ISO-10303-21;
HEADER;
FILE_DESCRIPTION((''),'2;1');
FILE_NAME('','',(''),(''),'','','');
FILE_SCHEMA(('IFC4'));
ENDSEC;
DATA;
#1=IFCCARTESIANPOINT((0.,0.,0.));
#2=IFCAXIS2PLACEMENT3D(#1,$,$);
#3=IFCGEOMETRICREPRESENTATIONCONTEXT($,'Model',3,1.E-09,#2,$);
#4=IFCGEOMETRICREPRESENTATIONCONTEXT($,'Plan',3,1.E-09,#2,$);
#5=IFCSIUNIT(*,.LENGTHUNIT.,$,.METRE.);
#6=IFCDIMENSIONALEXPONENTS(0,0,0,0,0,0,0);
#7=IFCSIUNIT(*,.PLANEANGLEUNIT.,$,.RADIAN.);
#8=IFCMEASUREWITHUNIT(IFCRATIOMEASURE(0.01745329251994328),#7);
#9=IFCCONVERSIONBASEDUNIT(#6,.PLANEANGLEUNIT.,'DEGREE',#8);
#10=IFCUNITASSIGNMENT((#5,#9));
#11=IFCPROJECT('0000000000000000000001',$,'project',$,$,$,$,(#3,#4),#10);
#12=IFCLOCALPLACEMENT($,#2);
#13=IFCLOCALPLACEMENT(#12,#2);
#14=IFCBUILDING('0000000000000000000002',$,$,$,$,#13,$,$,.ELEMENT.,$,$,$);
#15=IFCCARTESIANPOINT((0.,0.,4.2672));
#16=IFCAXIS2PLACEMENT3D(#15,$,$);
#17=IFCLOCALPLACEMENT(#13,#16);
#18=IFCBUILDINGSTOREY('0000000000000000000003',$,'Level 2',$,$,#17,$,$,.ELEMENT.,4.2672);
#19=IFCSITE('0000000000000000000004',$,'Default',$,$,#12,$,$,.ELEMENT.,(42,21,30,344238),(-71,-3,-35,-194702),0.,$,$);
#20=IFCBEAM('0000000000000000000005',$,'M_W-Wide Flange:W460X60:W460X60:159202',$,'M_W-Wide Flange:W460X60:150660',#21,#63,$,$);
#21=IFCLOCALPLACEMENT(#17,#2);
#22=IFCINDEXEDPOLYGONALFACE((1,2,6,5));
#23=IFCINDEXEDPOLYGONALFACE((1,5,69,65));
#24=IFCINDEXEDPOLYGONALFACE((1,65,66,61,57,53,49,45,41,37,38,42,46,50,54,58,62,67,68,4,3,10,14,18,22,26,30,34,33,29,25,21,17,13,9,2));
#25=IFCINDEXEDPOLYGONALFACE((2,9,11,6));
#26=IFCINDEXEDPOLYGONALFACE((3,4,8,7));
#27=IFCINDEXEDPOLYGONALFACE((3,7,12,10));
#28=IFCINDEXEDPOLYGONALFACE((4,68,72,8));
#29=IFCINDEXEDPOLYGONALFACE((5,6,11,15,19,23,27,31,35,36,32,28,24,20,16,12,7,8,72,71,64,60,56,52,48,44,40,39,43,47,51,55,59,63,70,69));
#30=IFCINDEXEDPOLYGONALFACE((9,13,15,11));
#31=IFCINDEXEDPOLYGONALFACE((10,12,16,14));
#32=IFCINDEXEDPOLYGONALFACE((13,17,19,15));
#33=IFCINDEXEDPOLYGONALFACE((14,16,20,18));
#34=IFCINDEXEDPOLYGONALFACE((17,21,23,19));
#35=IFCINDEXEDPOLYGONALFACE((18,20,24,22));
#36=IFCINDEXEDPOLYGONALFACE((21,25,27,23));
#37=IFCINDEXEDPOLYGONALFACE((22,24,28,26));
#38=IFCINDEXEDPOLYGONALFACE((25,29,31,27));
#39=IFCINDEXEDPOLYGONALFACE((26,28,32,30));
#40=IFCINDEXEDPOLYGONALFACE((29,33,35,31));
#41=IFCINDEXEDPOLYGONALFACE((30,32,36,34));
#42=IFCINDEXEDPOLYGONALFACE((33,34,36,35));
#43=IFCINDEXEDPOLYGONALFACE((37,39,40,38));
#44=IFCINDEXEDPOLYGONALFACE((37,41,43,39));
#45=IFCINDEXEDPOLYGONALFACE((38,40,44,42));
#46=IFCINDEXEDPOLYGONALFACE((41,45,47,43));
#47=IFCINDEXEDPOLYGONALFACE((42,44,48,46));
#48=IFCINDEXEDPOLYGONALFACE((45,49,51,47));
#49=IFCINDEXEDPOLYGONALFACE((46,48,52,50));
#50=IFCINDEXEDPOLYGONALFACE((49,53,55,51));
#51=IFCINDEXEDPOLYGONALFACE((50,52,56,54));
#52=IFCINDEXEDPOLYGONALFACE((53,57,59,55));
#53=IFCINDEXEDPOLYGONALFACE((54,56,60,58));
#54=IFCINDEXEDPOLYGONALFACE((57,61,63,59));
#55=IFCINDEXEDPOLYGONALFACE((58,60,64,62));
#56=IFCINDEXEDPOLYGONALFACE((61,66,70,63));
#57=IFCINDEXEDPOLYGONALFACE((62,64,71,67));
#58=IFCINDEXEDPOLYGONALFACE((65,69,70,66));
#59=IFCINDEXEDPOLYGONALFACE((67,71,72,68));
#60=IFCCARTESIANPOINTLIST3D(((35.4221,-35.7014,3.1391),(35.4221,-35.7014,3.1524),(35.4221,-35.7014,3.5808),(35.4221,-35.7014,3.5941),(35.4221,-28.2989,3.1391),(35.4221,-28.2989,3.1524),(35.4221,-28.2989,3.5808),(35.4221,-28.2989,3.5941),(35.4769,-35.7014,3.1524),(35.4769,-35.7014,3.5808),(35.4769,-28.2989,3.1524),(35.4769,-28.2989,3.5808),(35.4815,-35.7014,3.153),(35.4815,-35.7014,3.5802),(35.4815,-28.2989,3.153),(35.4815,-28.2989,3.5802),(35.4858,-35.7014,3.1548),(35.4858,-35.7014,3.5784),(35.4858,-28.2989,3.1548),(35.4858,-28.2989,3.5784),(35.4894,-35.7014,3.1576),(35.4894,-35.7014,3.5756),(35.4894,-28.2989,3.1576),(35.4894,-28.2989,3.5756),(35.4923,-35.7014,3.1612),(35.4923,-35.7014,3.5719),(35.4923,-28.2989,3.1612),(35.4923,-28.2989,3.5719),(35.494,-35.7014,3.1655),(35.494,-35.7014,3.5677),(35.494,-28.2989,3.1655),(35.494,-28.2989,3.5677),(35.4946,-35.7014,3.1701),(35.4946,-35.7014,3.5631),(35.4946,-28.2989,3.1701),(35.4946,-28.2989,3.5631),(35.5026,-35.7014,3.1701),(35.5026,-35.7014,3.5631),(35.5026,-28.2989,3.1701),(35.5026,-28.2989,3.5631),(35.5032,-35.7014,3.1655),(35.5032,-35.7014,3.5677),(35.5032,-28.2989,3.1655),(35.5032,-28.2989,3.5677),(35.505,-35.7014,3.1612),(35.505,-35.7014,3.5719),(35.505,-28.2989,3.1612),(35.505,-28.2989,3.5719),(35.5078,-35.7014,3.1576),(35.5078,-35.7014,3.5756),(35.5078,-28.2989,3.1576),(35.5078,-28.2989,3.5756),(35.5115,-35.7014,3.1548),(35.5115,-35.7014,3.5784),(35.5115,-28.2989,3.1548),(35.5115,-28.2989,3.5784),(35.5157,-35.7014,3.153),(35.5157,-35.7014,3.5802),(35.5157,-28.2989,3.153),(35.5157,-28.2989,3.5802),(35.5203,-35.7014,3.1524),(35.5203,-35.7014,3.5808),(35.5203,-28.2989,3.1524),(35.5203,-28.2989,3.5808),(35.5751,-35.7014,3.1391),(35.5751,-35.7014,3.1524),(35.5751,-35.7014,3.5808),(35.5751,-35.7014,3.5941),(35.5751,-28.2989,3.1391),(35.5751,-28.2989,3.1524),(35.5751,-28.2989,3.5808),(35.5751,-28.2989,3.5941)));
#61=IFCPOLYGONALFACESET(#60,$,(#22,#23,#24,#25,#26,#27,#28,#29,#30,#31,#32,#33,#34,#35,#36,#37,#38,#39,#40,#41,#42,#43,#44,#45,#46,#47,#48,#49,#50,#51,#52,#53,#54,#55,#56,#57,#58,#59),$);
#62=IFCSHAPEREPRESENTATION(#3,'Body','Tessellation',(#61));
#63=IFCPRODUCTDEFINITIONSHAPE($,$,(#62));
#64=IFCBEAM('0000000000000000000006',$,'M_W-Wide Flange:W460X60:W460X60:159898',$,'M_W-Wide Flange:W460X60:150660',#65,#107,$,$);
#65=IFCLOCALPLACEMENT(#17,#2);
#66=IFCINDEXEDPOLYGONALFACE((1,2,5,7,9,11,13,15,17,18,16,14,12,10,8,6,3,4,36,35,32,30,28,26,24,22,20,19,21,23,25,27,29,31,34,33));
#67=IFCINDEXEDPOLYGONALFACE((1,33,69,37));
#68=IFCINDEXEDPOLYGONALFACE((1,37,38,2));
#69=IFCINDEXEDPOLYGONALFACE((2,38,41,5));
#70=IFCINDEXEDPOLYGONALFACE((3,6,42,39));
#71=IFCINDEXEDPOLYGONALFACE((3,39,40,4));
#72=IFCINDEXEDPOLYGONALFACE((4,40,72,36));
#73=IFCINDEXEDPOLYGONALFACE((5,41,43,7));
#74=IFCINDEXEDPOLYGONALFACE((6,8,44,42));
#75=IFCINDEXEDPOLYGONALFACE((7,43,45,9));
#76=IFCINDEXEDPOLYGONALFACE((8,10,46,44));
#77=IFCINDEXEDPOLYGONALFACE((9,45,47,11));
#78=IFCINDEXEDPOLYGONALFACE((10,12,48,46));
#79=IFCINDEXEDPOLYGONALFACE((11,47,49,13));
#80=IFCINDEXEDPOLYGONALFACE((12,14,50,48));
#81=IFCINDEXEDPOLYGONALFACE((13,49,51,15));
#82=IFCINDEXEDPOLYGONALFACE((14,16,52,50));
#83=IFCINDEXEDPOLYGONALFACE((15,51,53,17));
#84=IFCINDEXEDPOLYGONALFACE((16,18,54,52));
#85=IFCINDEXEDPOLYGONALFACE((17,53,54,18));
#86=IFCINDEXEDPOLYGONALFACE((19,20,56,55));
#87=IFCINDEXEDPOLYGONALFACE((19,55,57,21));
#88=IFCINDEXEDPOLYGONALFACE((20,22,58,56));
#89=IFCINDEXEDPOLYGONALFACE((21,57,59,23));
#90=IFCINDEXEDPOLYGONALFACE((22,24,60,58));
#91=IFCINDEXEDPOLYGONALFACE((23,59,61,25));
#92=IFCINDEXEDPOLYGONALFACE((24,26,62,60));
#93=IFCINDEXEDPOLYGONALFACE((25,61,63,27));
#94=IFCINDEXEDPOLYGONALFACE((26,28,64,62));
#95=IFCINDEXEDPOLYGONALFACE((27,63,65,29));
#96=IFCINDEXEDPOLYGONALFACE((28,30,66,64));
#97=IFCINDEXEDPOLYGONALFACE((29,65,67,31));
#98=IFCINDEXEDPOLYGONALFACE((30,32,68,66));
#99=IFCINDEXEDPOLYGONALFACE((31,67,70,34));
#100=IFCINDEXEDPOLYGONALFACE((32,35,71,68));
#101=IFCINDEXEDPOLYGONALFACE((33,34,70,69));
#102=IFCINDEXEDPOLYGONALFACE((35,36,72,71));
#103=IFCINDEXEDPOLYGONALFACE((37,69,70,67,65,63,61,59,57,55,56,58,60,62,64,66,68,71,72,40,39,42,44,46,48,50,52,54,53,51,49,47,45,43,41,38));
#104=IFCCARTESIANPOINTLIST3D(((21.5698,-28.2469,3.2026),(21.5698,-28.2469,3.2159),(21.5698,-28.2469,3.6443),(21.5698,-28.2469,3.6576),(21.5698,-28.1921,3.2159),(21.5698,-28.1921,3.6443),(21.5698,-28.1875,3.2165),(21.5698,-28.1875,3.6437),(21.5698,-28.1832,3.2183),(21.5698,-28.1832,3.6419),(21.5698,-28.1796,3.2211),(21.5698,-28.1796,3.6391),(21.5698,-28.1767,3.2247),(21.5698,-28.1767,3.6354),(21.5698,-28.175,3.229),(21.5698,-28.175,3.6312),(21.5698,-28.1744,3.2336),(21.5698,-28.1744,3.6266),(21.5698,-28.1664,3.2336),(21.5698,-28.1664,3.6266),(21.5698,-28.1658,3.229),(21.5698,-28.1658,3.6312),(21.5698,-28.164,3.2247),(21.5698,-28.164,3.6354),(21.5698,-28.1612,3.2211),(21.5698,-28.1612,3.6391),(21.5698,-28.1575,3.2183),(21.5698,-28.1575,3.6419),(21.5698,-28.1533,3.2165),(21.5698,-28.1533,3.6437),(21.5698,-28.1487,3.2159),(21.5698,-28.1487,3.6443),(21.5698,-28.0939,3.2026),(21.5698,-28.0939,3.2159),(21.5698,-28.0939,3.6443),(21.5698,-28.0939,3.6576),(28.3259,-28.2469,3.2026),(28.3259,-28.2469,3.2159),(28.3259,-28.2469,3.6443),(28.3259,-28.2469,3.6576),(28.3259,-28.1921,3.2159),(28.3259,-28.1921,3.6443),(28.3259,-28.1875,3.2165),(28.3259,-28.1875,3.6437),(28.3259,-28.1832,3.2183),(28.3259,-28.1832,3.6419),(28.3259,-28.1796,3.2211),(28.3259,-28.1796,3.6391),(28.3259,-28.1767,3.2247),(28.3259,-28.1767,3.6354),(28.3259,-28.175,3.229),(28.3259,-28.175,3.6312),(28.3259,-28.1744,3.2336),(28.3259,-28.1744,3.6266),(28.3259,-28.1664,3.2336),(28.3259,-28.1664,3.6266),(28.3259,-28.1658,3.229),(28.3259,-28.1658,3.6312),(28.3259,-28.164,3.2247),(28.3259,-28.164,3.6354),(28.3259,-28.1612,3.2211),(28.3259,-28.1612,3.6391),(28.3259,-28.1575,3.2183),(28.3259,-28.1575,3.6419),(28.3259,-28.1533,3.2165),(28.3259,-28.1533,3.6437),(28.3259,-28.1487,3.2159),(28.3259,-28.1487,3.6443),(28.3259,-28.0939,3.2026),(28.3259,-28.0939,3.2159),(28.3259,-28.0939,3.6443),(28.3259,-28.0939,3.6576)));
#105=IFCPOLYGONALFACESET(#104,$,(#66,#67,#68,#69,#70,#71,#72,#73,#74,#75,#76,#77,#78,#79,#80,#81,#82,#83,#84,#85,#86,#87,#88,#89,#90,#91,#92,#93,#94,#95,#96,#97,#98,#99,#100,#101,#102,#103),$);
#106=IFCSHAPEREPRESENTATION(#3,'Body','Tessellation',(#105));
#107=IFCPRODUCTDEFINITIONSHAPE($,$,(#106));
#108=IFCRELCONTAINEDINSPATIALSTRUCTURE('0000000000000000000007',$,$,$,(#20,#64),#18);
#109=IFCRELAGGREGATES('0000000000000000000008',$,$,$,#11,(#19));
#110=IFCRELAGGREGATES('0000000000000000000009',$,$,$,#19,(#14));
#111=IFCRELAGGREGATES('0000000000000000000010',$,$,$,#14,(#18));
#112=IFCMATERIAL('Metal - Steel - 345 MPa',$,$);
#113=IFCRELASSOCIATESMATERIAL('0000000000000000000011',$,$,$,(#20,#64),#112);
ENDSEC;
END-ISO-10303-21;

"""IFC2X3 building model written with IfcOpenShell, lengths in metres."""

from ifc_helpers import new_model, entity, si_unit, converted_unit, frame, frame_2d, origin, place, context, project, spatial, polyline, circle_curve, parameter, trimmed, segment, composite_curve, outline, extrude, material, element, save


model = new_model("IFC2X3")

# Units and contexts
model_context = context("Model", 3, precision=1e-09, world=origin())
plan_context = context("Plan", 3, precision=1e-09, world=origin())
ifc_project = project(units=[si_unit("LENGTHUNIT", "METRE"), converted_unit("PLANEANGLEUNIT", "DEGREE", entity("IfcRatioMeasure", 0.01745329251994328), si_unit("PLANEANGLEUNIT", "RADIAN"), dimensions=[0, 0, 0, 0, 0, 0, 0])], contexts=[model_context, plan_context])

# Site, building, storey
site_placement = place(None, origin())
site = spatial("IfcSite", under=ifc_project, at=site_placement, Name="Default", CompositionType="ELEMENT", RefLatitude=(42, 21, 30, 344238), RefLongitude=(-71, -3, -35, -194702), RefElevation=0.0)
building_placement = place(site_placement, origin())
building = spatial("IfcBuilding", under=site, at=building_placement, CompositionType="ELEMENT")
storey_placement = place(building_placement, frame((0.0, 0.0, 4.2672)))
storey = spatial("IfcBuildingStorey", under=building, at=storey_placement, Name="Level 2", CompositionType="ELEMENT", Elevation=4.2672)

# Shared definitions
ifc_material = material(Name="Metal - Steel - 345 MPa")

# Beams
beam_1_placement = place(storey_placement, frame((35.4986, -35.8299, 3.6576)))
element("IfcBeam", 1, at=beam_1_placement, inside=storey, material=ifc_material, Name="M_W-Wide Flange:W460X60:W460X60:159202", ObjectType="M_W-Wide Flange:W460X60:150660", context=model_context, shape_type="SweptSolid", body=[
    extrude(outline(composite_curve([segment(polyline([(-0.0765, -0.2142), (-0.0765, -0.2275)]), True, "CONTINUOUS"), segment(polyline([(-0.0765, -0.2275), (0.0765, -0.2275)]), True, "CONTINUOUS"), segment(polyline([(0.0765, -0.2275), (0.0765, -0.2142)]), True, "CONTINUOUS"), segment(polyline([(0.0765, -0.2142), (0.0217, -0.2142)]), True, "CONTINUOUS"), segment(trimmed(circle_curve(frame_2d((0.0217, -0.1965), x_axis=(0.0, -1.0)), 0.0177), [parameter(270.0)], [parameter(360.0)], True, "PARAMETER"), False, "CONTINUOUS"), segment(polyline([(0.004, -0.1965), (0.004, 0.1965)]), True, "CONTINUOUS"), segment(trimmed(circle_curve(frame_2d((0.0217, 0.1965), x_axis=(-1.0, 0.0)), 0.0177), [parameter(270.0)], [parameter(360.0)], True, "PARAMETER"), False, "CONTINUOUS"), segment(polyline([(0.0217, 0.2142), (0.0765, 0.2142)]), True, "CONTINUOUS"), segment(polyline([(0.0765, 0.2142), (0.0765, 0.2275)]), True, "CONTINUOUS"), segment(polyline([(0.0765, 0.2275), (-0.0765, 0.2275)]), True, "CONTINUOUS"), segment(polyline([(-0.0765, 0.2275), (-0.0765, 0.2142)]), True, "CONTINUOUS"), segment(polyline([(-0.0765, 0.2142), (-0.0217, 0.2142)]), True, "CONTINUOUS"), segment(trimmed(circle_curve(frame_2d((-0.0217, 0.1965), x_axis=(0.0, 1.0)), 0.0177), [parameter(270.0)], [parameter(360.0)], True, "PARAMETER"), False, "CONTINUOUS"), segment(polyline([(-0.004, 0.1965), (-0.004, -0.1965)]), True, "CONTINUOUS"), segment(trimmed(circle_curve(frame_2d((-0.0217, -0.1965), x_axis=(1.0, 0.0)), 0.0177), [parameter(270.0)], [parameter(0.0)], True, "PARAMETER"), False, "CONTINUOUS"), segment(polyline([(-0.0217, -0.2142), (-0.0765, -0.2142)]), True, "CONTINUOUS")], self_intersect=False)), frame((0.0, 0.1285, -0.291), z_axis=(0.0, -1.0, 0.0), x_axis=(1.0, 0.0, 0.0)), (0.0, 0.0, -1.0), 7.4025),
])
beam_2_placement = place(storey_placement, frame((28.4279, -28.1704, 3.6576), z_axis=(0.0, 0.0, 1.0), x_axis=(0.0, 1.0, 0.0)))
element("IfcBeam", 2, at=beam_2_placement, inside=storey, material=ifc_material, Name="M_W-Wide Flange:W460X60:W460X60:159898", ObjectType="M_W-Wide Flange:W460X60:150660", context=model_context, shape_type="SweptSolid", body=[
    extrude(outline(composite_curve([segment(polyline([(0.2142, -0.0765), (0.2275, -0.0765)]), True, "CONTINUOUS"), segment(polyline([(0.2275, -0.0765), (0.2275, 0.0765)]), True, "CONTINUOUS"), segment(polyline([(0.2275, 0.0765), (0.2142, 0.0765)]), True, "CONTINUOUS"), segment(polyline([(0.2142, 0.0765), (0.2142, 0.0217)]), True, "CONTINUOUS"), segment(trimmed(circle_curve(frame_2d((0.1965, 0.0217), x_axis=(1.0, 0.0)), 0.0177), [parameter(270.0)], [parameter(360.0)], True, "PARAMETER"), False, "CONTINUOUS"), segment(polyline([(0.1965, 0.004), (-0.1965, 0.004)]), True, "CONTINUOUS"), segment(trimmed(circle_curve(frame_2d((-0.1965, 0.0217), x_axis=(0.0, -1.0)), 0.0177), [parameter(270.0)], [parameter(360.0)], True, "PARAMETER"), False, "CONTINUOUS"), segment(polyline([(-0.2142, 0.0217), (-0.2142, 0.0765)]), True, "CONTINUOUS"), segment(polyline([(-0.2142, 0.0765), (-0.2275, 0.0765)]), True, "CONTINUOUS"), segment(polyline([(-0.2275, 0.0765), (-0.2275, -0.0765)]), True, "CONTINUOUS"), segment(polyline([(-0.2275, -0.0765), (-0.2142, -0.0765)]), True, "CONTINUOUS"), segment(polyline([(-0.2142, -0.0765), (-0.2142, -0.0217)]), True, "CONTINUOUS"), segment(trimmed(circle_curve(frame_2d((-0.1965, -0.0217), x_axis=(-1.0, 0.0)), 0.0177), [parameter(270.0)], [parameter(360.0)], True, "PARAMETER"), False, "CONTINUOUS"), segment(polyline([(-0.1965, -0.004), (0.1965, -0.004)]), True, "CONTINUOUS"), segment(trimmed(circle_curve(frame_2d((0.1965, -0.0217), x_axis=(0.0, 1.0)), 0.0177), [parameter(270.0)], [parameter(0.0)], True, "PARAMETER"), False, "CONTINUOUS"), segment(polyline([(0.2142, -0.0217), (0.2142, -0.0765)]), True, "CONTINUOUS")], self_intersect=False)), frame((0.0, 6.8581, -0.2275), z_axis=(0.0, -1.0, 0.0), x_axis=(0.0, 0.0, -1.0)), (0.0, 0.0, 1.0), 6.7561),
])

save(model, "model.ifc")
